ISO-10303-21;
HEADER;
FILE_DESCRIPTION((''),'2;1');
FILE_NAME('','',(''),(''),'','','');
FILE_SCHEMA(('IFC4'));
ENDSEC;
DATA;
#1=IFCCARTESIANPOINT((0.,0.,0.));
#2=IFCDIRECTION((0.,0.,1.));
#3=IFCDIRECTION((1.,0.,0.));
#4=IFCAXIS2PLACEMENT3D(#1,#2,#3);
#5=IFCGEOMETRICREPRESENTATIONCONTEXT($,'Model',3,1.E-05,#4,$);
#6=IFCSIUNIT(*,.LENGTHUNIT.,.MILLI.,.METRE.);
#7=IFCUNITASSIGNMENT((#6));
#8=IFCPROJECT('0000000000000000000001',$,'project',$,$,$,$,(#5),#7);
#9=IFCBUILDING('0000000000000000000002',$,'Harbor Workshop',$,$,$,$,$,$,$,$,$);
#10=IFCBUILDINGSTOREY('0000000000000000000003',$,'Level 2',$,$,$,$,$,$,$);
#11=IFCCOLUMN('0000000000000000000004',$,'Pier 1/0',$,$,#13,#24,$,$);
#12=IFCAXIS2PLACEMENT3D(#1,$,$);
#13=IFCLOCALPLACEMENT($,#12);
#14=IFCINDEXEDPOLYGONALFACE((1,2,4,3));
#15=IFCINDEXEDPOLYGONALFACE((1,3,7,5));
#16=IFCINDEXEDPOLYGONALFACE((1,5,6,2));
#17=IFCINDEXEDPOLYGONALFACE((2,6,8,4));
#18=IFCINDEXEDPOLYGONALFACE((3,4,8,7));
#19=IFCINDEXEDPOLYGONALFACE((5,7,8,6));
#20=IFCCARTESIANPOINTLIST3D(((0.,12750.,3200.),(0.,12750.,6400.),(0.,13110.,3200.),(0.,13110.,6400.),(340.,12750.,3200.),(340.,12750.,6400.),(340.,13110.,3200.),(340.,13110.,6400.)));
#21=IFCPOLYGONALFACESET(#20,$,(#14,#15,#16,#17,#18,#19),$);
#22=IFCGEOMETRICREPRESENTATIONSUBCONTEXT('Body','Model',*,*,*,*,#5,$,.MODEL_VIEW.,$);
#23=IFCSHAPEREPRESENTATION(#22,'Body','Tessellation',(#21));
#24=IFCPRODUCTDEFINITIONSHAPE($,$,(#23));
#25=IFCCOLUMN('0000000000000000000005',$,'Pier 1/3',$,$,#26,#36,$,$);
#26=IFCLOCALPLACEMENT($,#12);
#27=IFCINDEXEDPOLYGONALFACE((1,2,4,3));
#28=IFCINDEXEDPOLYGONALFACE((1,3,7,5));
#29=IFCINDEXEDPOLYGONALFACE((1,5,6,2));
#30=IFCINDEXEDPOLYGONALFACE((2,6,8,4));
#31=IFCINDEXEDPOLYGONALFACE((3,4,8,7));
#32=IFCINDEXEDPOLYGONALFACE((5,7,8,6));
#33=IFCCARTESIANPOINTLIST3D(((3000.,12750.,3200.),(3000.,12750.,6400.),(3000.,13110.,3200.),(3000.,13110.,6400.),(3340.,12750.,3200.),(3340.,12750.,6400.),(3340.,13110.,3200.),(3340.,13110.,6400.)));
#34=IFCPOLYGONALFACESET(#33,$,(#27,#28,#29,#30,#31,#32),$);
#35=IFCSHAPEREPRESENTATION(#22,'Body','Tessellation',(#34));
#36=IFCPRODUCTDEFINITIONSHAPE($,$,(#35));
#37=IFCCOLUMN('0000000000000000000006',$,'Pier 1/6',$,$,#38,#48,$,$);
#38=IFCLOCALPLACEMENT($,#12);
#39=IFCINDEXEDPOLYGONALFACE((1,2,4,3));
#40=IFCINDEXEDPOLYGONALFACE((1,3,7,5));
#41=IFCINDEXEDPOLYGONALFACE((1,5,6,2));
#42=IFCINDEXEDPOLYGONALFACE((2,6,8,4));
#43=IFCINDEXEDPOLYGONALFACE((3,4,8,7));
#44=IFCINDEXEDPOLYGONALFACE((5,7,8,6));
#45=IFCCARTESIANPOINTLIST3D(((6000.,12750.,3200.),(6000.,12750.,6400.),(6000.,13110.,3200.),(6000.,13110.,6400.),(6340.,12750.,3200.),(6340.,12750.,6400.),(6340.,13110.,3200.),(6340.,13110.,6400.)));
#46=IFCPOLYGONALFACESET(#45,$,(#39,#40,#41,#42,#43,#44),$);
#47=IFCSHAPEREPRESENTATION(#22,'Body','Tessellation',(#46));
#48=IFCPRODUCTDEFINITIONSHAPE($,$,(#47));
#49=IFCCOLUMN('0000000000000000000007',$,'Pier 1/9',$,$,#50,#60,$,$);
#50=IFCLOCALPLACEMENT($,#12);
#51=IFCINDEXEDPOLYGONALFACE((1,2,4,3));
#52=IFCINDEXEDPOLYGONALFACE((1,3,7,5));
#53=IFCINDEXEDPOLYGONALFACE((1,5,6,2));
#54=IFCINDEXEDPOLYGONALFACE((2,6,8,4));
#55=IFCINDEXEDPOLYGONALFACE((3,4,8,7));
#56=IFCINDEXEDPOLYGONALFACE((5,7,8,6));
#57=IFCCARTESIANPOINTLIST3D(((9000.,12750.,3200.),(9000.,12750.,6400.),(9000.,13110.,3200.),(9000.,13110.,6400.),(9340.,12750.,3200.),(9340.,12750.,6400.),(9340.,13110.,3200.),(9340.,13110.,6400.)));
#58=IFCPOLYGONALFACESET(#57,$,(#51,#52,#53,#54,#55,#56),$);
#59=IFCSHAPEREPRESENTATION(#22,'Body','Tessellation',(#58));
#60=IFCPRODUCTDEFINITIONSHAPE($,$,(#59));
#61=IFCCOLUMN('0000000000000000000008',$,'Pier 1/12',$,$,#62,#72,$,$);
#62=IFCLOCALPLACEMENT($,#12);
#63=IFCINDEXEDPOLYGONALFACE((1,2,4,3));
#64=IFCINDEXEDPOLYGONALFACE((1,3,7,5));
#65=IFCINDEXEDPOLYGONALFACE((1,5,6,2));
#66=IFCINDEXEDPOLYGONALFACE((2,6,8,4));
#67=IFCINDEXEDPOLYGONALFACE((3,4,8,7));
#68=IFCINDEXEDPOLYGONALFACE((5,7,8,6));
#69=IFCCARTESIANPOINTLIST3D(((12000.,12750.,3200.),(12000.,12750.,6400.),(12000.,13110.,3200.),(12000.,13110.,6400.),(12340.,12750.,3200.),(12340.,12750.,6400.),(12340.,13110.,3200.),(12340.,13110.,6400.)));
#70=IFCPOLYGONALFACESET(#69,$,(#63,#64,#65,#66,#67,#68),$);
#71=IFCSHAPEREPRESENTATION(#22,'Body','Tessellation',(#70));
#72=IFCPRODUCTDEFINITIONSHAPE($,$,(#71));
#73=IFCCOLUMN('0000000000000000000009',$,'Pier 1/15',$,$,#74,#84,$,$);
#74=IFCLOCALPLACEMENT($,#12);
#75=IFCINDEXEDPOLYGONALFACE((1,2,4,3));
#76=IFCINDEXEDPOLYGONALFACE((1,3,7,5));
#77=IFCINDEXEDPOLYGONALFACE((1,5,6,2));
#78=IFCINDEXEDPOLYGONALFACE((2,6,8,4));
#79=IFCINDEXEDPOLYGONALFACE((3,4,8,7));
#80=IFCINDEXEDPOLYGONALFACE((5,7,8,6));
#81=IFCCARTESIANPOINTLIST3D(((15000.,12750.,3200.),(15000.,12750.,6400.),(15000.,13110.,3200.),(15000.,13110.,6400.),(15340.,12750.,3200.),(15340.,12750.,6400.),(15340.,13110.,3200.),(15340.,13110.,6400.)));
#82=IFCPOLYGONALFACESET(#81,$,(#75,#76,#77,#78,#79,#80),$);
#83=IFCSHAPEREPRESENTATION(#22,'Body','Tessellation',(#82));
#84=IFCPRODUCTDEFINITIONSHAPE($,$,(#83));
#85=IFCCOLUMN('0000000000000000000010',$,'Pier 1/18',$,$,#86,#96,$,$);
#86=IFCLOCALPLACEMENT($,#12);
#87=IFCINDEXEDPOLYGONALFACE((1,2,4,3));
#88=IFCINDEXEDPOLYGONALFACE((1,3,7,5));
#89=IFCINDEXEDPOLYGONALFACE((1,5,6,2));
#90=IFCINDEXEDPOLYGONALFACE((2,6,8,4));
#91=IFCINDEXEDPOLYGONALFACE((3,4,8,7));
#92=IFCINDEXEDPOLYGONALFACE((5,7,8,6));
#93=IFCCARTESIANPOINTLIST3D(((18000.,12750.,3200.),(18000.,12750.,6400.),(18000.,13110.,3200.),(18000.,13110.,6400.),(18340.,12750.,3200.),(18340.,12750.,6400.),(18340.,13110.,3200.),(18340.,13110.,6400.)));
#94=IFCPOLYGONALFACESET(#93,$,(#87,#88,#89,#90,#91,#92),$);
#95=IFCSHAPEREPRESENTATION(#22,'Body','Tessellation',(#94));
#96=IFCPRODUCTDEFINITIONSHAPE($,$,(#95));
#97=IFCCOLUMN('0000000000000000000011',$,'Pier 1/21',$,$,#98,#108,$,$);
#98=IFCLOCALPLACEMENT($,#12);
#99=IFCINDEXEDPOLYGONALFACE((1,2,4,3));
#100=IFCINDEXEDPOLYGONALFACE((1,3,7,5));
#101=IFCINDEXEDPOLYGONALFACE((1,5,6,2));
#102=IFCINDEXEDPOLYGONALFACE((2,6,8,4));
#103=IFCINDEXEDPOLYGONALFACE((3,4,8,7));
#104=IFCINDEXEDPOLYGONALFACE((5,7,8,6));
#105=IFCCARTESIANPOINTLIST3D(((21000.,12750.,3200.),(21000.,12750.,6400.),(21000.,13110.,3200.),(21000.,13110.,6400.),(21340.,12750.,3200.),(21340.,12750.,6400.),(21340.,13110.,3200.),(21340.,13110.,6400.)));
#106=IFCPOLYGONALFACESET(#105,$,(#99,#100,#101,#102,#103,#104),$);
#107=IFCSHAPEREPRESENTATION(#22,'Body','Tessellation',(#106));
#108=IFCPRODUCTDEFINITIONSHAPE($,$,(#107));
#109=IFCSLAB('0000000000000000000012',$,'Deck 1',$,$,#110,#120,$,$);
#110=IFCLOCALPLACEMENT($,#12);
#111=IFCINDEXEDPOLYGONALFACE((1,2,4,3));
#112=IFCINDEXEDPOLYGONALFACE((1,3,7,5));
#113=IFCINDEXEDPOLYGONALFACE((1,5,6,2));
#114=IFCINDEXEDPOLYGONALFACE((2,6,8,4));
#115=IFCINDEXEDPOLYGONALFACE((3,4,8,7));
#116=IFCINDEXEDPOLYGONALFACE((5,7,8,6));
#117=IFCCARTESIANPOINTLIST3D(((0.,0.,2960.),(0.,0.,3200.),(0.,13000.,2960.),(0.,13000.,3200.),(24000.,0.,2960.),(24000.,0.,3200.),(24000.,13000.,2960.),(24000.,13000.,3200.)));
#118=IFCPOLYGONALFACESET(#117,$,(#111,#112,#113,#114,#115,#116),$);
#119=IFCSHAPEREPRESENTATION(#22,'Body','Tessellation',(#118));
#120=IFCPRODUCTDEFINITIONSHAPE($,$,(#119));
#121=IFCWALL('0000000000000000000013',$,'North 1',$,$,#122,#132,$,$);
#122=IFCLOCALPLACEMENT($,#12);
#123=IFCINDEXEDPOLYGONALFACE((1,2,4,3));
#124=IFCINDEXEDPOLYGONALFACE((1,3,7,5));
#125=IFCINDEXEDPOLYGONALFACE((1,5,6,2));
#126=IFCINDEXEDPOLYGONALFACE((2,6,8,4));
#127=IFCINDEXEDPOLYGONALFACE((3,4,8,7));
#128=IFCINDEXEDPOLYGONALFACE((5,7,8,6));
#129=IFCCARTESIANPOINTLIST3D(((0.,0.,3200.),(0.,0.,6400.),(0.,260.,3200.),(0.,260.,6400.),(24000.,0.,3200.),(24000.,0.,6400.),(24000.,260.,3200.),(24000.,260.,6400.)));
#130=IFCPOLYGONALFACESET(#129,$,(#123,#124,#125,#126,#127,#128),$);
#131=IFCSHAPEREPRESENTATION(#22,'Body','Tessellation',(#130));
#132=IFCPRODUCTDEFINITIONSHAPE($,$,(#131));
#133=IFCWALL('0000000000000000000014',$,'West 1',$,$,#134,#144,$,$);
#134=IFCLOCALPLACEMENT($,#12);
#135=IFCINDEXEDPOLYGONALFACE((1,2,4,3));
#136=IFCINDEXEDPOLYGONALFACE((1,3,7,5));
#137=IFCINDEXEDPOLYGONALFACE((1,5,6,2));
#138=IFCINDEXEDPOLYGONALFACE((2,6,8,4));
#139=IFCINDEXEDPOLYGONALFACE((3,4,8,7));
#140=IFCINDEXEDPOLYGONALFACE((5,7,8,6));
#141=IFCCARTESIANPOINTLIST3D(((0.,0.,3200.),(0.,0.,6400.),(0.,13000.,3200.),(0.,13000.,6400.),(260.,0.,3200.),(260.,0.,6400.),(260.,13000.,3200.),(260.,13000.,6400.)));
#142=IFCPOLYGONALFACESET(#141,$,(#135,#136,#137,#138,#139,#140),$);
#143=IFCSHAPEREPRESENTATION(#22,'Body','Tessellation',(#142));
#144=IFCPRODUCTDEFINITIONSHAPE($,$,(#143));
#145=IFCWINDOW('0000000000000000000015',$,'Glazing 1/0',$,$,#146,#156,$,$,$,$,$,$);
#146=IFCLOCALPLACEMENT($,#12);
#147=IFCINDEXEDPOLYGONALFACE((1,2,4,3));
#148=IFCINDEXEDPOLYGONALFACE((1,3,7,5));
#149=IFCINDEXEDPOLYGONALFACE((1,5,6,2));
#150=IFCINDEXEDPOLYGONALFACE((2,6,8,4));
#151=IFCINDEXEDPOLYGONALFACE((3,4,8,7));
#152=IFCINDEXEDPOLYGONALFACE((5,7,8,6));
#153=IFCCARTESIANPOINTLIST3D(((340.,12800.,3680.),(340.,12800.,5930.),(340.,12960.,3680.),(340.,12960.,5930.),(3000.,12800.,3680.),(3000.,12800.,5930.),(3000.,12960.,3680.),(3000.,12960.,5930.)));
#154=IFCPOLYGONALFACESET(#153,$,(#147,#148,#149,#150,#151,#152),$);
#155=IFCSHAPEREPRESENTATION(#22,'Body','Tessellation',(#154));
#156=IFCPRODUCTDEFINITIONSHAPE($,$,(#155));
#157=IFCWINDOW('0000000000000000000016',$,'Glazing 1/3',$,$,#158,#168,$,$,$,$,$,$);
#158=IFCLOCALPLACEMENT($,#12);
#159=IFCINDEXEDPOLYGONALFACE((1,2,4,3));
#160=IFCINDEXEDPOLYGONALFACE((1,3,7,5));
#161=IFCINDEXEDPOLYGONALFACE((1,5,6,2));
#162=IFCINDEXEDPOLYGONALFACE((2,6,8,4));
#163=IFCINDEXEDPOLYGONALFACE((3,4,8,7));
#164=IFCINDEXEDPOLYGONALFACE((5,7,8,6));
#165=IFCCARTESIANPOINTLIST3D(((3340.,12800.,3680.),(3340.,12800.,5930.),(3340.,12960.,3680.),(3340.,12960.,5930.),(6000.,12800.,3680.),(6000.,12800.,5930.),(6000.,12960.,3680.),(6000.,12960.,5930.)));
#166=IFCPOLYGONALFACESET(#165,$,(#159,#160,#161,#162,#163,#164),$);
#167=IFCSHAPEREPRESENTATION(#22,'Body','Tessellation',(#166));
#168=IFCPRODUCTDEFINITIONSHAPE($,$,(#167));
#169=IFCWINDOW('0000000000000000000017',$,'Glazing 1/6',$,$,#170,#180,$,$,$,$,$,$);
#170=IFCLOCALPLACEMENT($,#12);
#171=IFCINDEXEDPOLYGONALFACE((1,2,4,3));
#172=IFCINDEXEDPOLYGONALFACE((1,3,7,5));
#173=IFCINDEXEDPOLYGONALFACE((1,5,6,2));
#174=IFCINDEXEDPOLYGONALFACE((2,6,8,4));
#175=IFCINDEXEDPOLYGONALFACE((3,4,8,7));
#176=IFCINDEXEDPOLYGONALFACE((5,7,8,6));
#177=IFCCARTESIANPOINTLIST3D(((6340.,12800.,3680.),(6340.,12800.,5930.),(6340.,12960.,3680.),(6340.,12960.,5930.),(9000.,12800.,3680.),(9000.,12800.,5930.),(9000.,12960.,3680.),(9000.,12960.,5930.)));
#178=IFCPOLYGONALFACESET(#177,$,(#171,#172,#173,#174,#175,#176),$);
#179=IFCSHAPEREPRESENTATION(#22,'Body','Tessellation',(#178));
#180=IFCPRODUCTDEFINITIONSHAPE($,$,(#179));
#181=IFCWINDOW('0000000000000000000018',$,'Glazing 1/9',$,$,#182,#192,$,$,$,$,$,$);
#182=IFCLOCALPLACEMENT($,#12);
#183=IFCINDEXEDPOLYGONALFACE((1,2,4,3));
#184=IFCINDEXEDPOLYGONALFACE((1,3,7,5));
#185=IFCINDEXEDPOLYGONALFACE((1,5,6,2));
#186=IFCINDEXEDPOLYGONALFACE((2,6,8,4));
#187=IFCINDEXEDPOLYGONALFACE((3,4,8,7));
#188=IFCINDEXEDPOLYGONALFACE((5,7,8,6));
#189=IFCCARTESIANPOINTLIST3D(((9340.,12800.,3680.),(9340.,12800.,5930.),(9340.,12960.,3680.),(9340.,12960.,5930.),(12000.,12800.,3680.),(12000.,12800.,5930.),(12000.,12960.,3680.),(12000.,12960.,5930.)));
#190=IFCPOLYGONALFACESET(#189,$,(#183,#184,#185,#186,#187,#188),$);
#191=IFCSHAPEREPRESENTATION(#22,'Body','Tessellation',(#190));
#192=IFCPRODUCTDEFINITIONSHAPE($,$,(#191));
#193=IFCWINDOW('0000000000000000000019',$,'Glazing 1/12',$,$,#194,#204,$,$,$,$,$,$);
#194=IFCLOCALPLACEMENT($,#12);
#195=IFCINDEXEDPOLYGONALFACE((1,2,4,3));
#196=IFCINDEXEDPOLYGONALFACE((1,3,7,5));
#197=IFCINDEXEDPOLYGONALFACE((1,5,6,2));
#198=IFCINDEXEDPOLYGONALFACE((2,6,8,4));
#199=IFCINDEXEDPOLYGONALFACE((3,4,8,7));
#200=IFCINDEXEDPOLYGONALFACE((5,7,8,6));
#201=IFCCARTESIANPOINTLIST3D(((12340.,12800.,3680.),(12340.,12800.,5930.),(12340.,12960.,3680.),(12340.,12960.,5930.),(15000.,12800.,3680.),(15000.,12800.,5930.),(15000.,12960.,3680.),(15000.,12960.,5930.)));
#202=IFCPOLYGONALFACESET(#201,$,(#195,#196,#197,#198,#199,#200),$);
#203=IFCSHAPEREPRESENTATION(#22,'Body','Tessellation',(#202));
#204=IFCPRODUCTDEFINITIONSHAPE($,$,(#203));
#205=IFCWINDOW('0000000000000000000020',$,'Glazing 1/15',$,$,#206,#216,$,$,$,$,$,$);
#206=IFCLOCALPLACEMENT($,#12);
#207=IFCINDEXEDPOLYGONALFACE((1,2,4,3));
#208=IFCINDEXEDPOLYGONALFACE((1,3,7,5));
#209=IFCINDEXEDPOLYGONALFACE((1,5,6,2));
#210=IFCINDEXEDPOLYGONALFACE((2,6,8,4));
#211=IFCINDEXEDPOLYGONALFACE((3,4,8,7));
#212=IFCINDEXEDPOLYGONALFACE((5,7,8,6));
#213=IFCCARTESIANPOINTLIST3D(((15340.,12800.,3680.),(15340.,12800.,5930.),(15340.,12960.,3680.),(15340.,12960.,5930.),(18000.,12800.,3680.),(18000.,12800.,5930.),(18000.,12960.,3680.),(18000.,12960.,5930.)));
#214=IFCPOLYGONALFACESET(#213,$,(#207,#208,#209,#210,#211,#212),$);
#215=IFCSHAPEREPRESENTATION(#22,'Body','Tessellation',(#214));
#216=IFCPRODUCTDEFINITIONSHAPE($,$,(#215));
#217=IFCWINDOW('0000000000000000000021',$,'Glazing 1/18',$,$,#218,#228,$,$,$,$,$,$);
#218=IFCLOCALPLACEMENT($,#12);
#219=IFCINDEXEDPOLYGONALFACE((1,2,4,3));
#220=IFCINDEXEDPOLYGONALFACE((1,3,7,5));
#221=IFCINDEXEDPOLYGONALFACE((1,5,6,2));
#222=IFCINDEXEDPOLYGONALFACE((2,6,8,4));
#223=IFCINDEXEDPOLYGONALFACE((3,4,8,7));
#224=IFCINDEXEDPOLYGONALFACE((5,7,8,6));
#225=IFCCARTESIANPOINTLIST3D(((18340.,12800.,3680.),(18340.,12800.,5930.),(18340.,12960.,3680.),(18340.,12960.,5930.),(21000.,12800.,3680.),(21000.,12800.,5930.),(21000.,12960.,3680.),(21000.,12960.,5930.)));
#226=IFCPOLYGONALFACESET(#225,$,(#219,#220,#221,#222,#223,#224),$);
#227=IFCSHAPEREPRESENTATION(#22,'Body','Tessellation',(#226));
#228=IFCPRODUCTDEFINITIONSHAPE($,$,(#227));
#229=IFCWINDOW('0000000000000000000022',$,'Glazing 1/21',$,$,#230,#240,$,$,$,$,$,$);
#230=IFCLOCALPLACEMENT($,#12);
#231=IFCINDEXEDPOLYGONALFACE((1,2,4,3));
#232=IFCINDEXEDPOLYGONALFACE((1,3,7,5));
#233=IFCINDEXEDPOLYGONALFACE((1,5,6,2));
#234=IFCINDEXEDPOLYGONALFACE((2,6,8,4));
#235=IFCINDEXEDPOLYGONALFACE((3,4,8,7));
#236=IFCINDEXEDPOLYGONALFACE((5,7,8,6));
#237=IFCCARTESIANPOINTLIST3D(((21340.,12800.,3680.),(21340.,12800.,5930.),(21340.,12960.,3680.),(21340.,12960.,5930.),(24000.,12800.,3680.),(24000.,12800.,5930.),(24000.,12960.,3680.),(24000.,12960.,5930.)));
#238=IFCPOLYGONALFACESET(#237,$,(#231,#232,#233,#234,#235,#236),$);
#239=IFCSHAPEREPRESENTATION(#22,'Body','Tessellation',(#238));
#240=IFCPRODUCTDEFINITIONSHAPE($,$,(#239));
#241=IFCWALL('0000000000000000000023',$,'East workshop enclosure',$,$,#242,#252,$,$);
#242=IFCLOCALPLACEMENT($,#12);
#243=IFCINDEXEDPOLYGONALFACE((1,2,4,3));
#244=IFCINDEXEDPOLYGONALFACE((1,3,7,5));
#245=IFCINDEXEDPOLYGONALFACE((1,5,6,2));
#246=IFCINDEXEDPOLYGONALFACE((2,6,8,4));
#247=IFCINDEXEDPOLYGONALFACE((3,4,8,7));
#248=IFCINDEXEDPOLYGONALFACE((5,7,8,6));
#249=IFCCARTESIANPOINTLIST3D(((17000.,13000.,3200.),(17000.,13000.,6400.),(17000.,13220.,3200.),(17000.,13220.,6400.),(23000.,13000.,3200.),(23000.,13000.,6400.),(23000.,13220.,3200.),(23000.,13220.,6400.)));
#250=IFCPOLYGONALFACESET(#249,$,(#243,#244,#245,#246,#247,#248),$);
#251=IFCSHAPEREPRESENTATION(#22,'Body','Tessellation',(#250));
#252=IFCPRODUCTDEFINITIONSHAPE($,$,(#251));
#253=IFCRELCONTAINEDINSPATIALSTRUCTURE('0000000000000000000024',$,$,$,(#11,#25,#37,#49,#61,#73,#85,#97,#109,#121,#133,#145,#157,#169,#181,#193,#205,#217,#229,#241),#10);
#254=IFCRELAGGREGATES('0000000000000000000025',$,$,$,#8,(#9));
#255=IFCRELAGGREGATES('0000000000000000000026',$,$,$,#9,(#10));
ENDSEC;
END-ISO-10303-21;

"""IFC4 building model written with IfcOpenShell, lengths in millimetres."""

from ifc_helpers import new_model, si_unit, frame, origin_with_axes, place, context, subcontext, project, spatial, indexed_curve, outline, extrude, element, save


model = new_model("IFC4")

# Units and contexts
model_context = context("Model", 3, precision=1e-05, world=origin_with_axes())
body_context = subcontext(model_context, "Body", "Model", "MODEL_VIEW")
ifc_project = project(units=[si_unit("LENGTHUNIT", "METRE", prefix="MILLI")], contexts=[model_context])

# Building, storey
building = spatial("IfcBuilding", under=ifc_project, Name="Harbor Workshop")
storey = spatial("IfcBuildingStorey", under=building, Name="Level 2")

# Columns
for number, where, z_axis, x_axis, name in (
    (1, (0.0, 12750.0, 3200.0), (0.0, 0.0, 1.0), (1.0, 0.0, 0.0), "Pier 1/0"),
    (2, (3000.0, 12750.0, 3200.0), (0.0, 0.0, 1.0), (1.0, 0.0, 0.0), "Pier 1/3"),
    (3, (6000.0, 12750.0, 3200.0), (0.0, 0.0, 1.0), (1.0, 0.0, 0.0), "Pier 1/6"),
    (4, (9000.0, 12750.0, 3200.0), (0.0, 0.0, 1.0), (1.0, 0.0, 0.0), "Pier 1/9"),
    (5, (12000.0, 12750.0, 3200.0), (0.0, 0.0, 1.0), (1.0, 0.0, 0.0), "Pier 1/12"),
    (6, (15000.0, 12750.0, 3200.0), (0.0, 0.0, 1.0), (1.0, 0.0, 0.0), "Pier 1/15"),
    (7, (18000.0, 12750.0, 3200.0), (0.0, 0.0, 1.0), (1.0, 0.0, 0.0), "Pier 1/18"),
    (8, (21000.0, 12750.0, 3200.0), (0.0, 0.0, 1.0), (1.0, 0.0, 0.0), "Pier 1/21"),
):
    element("IfcColumn", number, at=place(None, frame(where, z_axis=z_axis, x_axis=x_axis)), inside=storey, Name=name, context=body_context, shape_type="SweptSolid", body=[
        extrude(outline(indexed_curve([(0.0, 0.0), (0.0, 360.0), (340.0, 360.0), (340.0, 0.0), (0.0, 0.0)], self_intersect=False)), origin_with_axes(), (0.0, 0.0, 1.0), 3200.0),
    ])

# Slab
slab_placement = place(None, frame((0.0, 0.0, 2960.0), z_axis=(0.0, 0.0, 1.0), x_axis=(1.0, 0.0, 0.0)))
element("IfcSlab", 9, at=slab_placement, inside=storey, Name="Deck 1", context=body_context, shape_type="SweptSolid", body=[
    extrude(outline(indexed_curve([(0.0, 0.0), (0.0, 13000.0), (24000.0, 13000.0), (24000.0, 0.0), (0.0, 0.0)], self_intersect=False)), origin_with_axes(), (0.0, 0.0, 1.0), 240.0),
])

# Walls
wall_1_placement = place(None, frame((0.0, 0.0, 3200.0), z_axis=(0.0, 0.0, 1.0), x_axis=(1.0, 0.0, 0.0)))
element("IfcWall", 10, at=wall_1_placement, inside=storey, Name="North 1", context=body_context, shape_type="SweptSolid", body=[
    extrude(outline(indexed_curve([(0.0, 0.0), (0.0, 260.0), (24000.0, 260.0), (24000.0, 0.0), (0.0, 0.0)], self_intersect=False)), origin_with_axes(), (0.0, 0.0, 1.0), 3200.0),
])
wall_2_placement = place(None, frame((260.0, 0.0, 3200.0), z_axis=(0.0, 0.0, 1.0), x_axis=(0.0, 1.0, 0.0)))
element("IfcWall", 11, at=wall_2_placement, inside=storey, Name="West 1", context=body_context, shape_type="SweptSolid", body=[
    extrude(outline(indexed_curve([(0.0, 0.0), (0.0, 260.0), (13000.0, 260.0), (13000.0, 0.0), (0.0, 0.0)], self_intersect=False)), origin_with_axes(), (0.0, 0.0, 1.0), 3200.0),
])

# Windows
for number, where, z_axis, x_axis, name in (
    (12, (340.0, 12800.0, 3680.0), (0.0, 0.0, 1.0), (1.0, 0.0, 0.0), "Glazing 1/0"),
    (13, (3340.0, 12800.0, 3680.0), (0.0, 0.0, 1.0), (1.0, 0.0, 0.0), "Glazing 1/3"),
    (14, (6340.0, 12800.0, 3680.0), (0.0, 0.0, 1.0), (1.0, 0.0, 0.0), "Glazing 1/6"),
    (15, (9340.0, 12800.0, 3680.0), (0.0, 0.0, 1.0), (1.0, 0.0, 0.0), "Glazing 1/9"),
    (16, (12340.0, 12800.0, 3680.0), (0.0, 0.0, 1.0), (1.0, 0.0, 0.0), "Glazing 1/12"),
    (17, (15340.0, 12800.0, 3680.0), (0.0, 0.0, 1.0), (1.0, 0.0, 0.0), "Glazing 1/15"),
    (18, (18340.0, 12800.0, 3680.0), (0.0, 0.0, 1.0), (1.0, 0.0, 0.0), "Glazing 1/18"),
    (19, (21340.0, 12800.0, 3680.0), (0.0, 0.0, 1.0), (1.0, 0.0, 0.0), "Glazing 1/21"),
):
    element("IfcWindow", number, at=place(None, frame(where, z_axis=z_axis, x_axis=x_axis)), inside=storey, Name=name, context=body_context, shape_type="SweptSolid", body=[
        extrude(outline(indexed_curve([(0.0, 0.0), (0.0, 160.0), (2660.0, 160.0), (2660.0, 0.0), (0.0, 0.0)], self_intersect=False)), origin_with_axes(), (0.0, 0.0, 1.0), 2250.0),
    ])

# Wall
wall_3_placement = place(None, frame((17000.0, 13000.0, 3200.0), z_axis=(0.0, 0.0, 1.0), x_axis=(1.0, 0.0, 0.0)))
element("IfcWall", 20, at=wall_3_placement, inside=storey, Name="East workshop enclosure", context=body_context, shape_type="SweptSolid", body=[
    extrude(outline(indexed_curve([(0.0, 0.0), (0.0, 220.0), (6000.0, 220.0), (6000.0, 0.0), (0.0, 0.0)], self_intersect=False)), origin_with_axes(), (0.0, 0.0, 1.0), 3200.0),
])

save(model, "model.ifc")
